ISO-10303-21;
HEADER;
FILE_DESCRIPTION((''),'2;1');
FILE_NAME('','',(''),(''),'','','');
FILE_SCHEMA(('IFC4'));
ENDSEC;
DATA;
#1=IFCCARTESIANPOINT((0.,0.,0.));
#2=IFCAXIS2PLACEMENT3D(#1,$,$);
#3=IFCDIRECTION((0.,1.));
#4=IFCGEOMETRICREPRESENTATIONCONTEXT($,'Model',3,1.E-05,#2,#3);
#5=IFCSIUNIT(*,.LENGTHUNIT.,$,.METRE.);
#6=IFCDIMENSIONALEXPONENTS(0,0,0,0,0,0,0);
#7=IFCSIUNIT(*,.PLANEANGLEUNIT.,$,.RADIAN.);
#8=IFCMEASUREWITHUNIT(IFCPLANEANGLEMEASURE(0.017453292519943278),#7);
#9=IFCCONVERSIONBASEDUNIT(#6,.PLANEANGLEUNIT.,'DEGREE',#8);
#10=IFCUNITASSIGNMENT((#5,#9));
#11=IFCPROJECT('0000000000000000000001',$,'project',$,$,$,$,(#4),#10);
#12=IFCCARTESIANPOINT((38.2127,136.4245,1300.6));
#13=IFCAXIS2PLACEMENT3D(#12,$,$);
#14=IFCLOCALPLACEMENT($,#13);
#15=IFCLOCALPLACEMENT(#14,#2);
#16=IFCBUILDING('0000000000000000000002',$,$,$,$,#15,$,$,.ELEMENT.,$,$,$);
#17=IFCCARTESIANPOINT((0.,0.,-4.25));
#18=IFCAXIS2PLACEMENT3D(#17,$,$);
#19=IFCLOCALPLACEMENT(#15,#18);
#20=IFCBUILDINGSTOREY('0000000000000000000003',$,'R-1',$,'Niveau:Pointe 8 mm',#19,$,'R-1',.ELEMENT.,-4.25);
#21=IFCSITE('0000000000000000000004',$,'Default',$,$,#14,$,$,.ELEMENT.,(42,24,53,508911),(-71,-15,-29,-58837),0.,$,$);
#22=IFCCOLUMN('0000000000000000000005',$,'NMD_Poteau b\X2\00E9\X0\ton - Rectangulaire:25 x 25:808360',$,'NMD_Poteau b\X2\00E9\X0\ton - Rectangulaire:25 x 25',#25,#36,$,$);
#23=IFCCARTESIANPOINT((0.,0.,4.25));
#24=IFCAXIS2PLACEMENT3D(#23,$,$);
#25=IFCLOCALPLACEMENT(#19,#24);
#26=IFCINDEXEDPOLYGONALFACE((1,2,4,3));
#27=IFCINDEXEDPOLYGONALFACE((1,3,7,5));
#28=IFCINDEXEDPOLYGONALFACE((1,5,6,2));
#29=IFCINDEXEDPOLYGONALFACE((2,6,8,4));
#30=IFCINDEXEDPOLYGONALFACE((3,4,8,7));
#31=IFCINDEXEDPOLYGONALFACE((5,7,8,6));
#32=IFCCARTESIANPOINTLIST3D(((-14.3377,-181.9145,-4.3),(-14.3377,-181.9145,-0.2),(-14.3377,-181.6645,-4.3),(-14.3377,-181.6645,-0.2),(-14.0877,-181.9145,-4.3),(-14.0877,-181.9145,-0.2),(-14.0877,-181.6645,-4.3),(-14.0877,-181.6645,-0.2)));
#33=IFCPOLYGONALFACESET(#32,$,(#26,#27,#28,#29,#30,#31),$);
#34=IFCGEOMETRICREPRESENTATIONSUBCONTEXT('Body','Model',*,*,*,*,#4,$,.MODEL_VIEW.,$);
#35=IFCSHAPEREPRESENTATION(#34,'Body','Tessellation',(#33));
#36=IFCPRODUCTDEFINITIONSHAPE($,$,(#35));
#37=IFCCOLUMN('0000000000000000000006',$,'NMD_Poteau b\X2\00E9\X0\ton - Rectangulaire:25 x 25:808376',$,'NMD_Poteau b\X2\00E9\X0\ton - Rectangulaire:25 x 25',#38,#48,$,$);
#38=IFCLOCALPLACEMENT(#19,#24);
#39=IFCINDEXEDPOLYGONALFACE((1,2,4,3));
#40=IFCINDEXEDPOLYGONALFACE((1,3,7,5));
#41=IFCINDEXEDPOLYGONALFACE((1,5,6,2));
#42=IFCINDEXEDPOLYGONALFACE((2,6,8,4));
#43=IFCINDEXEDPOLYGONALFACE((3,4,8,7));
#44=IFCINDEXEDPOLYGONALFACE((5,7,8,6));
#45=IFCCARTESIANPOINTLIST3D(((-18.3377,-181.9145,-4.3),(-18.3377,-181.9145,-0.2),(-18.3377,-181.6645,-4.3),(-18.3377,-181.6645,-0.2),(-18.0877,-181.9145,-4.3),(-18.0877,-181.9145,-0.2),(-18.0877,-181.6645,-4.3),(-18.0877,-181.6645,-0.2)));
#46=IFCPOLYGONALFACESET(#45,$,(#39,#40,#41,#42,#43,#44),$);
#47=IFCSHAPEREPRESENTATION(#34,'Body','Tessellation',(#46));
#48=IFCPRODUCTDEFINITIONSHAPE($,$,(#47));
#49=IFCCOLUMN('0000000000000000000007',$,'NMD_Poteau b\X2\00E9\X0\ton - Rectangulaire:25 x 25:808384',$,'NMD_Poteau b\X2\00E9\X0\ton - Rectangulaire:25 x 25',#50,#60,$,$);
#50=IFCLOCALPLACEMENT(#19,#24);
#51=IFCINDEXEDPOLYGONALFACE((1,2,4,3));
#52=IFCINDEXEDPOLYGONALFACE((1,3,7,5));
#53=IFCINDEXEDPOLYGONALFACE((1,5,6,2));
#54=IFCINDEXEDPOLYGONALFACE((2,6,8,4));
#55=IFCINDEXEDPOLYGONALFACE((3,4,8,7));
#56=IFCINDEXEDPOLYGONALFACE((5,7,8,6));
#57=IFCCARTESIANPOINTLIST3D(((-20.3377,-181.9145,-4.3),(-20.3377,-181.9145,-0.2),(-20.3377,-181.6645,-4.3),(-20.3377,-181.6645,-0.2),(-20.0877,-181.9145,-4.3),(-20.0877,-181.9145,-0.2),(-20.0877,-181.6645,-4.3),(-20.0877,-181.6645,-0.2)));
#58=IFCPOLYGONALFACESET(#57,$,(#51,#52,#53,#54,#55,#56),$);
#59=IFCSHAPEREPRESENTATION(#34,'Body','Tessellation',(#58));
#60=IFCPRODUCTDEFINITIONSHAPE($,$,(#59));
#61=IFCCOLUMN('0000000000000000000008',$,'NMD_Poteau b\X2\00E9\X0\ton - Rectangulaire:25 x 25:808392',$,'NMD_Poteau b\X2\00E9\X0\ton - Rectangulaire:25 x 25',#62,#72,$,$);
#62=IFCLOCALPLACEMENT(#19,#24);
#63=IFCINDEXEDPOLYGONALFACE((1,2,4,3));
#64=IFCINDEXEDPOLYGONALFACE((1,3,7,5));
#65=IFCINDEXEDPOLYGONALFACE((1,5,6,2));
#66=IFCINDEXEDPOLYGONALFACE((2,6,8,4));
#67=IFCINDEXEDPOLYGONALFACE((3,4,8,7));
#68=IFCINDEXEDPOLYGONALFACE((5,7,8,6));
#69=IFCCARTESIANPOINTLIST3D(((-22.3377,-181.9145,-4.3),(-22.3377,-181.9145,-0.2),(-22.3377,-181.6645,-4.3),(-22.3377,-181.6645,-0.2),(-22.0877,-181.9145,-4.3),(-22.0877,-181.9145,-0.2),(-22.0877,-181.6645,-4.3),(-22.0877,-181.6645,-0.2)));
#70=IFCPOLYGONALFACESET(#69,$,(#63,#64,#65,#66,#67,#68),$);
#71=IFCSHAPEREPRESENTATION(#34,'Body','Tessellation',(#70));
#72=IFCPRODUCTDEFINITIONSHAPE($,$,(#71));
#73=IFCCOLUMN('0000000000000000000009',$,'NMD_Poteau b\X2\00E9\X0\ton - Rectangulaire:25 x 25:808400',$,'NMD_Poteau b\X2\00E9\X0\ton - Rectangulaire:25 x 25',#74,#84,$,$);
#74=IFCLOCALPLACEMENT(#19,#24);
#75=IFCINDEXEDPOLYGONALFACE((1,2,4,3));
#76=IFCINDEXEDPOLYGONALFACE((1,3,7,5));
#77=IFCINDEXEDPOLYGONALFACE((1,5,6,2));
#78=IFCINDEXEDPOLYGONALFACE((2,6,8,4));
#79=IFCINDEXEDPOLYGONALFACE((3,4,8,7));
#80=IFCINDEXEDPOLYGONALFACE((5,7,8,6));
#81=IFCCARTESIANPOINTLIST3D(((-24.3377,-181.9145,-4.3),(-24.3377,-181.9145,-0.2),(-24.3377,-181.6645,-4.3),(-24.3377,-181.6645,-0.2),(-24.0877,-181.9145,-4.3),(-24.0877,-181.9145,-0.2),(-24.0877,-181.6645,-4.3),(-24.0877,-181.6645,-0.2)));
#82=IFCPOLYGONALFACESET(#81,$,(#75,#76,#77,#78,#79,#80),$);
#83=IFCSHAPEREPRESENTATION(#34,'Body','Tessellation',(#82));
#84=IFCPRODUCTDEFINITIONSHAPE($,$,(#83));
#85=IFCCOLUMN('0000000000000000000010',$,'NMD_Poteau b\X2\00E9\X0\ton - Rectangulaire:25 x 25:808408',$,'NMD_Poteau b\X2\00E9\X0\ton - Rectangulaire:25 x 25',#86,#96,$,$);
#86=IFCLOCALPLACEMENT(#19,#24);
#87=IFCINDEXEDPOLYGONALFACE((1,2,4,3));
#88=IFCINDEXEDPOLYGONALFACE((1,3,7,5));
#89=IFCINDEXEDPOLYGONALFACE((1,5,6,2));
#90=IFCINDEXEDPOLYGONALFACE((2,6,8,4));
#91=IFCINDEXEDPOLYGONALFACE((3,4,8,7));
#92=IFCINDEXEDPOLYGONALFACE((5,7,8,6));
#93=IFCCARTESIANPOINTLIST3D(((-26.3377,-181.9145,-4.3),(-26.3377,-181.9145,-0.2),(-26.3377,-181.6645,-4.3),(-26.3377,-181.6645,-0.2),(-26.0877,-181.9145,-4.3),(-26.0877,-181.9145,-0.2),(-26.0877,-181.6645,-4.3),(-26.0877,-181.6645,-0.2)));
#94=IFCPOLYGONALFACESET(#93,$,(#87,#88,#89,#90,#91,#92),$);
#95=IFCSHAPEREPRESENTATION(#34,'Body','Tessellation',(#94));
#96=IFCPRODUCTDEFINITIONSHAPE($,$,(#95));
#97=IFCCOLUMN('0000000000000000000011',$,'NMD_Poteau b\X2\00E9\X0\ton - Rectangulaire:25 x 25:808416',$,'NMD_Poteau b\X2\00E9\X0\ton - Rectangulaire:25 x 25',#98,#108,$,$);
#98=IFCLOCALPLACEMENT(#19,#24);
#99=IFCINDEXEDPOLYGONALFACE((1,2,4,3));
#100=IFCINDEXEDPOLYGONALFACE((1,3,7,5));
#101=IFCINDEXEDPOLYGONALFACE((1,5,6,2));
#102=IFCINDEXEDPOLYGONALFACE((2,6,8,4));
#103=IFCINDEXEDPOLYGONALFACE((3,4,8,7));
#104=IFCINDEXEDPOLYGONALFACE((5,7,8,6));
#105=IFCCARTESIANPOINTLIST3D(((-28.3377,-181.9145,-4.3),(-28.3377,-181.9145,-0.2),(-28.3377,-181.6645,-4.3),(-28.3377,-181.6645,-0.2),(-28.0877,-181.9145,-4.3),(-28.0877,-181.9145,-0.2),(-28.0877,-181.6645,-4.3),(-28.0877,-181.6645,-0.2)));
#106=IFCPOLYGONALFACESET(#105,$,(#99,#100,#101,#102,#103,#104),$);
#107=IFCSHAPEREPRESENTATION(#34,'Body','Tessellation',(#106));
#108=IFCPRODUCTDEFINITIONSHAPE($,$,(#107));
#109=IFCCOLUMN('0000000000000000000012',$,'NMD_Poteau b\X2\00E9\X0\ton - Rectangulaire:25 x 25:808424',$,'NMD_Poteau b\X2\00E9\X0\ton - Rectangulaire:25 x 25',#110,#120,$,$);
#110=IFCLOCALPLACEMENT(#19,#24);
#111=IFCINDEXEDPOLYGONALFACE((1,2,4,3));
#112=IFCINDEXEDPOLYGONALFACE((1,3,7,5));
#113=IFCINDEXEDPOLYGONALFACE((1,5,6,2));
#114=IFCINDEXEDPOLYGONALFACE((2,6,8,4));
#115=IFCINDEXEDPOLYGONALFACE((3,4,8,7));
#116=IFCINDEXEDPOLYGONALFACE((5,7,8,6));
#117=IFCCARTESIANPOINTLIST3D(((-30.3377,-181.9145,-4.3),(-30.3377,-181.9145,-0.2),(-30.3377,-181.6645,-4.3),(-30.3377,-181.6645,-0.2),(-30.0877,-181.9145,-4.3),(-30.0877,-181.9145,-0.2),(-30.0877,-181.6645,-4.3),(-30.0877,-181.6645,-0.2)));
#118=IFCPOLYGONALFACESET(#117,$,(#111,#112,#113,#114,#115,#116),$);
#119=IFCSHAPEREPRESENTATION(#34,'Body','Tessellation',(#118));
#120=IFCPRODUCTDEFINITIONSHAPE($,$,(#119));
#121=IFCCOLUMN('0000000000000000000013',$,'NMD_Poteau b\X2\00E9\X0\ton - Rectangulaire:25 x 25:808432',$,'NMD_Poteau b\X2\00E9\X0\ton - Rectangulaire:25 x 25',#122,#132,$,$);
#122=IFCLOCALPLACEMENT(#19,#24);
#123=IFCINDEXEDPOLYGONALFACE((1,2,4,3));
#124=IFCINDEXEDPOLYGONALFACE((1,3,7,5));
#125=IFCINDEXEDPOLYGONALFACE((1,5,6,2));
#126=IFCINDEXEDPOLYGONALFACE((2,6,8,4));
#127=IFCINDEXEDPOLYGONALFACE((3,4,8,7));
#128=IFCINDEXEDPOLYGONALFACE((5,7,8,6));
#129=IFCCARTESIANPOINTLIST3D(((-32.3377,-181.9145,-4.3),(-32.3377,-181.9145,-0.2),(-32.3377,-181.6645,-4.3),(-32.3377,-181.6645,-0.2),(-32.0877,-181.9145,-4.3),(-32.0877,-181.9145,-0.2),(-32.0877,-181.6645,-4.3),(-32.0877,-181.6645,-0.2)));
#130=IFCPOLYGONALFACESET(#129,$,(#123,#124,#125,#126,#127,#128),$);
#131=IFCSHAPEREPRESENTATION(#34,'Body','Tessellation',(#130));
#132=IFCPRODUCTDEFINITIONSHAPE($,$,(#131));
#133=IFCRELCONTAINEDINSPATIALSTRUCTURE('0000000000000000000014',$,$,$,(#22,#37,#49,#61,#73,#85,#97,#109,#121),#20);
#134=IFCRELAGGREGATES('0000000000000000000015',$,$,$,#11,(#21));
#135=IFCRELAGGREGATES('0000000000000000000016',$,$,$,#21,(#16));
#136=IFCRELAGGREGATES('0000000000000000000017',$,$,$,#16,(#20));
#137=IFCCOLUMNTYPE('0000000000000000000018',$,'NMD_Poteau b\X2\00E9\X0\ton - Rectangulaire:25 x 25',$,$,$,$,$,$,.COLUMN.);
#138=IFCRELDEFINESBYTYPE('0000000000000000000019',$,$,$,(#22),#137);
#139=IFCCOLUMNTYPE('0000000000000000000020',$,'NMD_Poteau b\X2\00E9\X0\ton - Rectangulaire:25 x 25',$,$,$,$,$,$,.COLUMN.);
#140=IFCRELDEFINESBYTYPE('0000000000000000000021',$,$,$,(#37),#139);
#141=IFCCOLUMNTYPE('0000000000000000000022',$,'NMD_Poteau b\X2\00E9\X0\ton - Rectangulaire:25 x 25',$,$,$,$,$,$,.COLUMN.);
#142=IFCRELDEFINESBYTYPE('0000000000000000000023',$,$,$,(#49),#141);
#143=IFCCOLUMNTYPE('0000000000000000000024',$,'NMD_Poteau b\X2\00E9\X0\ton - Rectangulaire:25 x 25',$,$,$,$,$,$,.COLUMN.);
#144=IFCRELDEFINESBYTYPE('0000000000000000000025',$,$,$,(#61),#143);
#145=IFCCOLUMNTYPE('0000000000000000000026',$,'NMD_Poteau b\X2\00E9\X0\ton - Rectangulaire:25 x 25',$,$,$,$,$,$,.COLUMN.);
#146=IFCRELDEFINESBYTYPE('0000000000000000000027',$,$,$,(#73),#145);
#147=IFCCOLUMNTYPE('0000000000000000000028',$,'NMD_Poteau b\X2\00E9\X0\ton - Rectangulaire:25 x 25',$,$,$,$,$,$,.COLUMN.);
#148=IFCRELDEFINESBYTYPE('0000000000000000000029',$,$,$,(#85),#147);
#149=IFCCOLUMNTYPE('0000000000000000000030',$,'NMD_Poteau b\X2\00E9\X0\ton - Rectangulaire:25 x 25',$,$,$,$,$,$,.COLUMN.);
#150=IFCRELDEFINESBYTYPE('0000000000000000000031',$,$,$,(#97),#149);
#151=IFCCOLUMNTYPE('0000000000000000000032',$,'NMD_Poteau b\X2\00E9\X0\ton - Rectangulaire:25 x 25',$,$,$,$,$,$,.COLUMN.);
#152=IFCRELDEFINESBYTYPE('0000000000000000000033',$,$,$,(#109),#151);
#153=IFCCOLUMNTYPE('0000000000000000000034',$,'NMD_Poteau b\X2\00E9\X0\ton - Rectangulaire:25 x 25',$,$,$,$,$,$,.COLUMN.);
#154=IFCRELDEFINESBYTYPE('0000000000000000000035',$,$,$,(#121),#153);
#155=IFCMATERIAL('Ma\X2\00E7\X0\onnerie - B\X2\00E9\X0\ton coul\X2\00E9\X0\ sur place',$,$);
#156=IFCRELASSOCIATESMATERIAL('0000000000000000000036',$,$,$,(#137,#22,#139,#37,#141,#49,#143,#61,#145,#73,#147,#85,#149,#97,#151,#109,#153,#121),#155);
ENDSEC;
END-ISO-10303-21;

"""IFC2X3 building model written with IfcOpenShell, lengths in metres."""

from ifc_helpers import new_model, entity, si_unit, converted_unit, direction, frame, frame_2d, origin, place, context, subcontext, project, spatial, rectangle, extrude, source, transform, mapped, material, type_object, type_shapes, element, save


model = new_model("IFC2X3")

# Units and contexts
model_context = context("Model", 3, precision=1e-05, world=origin(), true_north=direction((0.0, 1.0)))
body_context = subcontext(model_context, "Body", "Model", "MODEL_VIEW")
ifc_project = project(units=[si_unit("LENGTHUNIT", "METRE"), converted_unit("PLANEANGLEUNIT", "DEGREE", entity("IfcPlaneAngleMeasure", 0.017453292519943278), si_unit("PLANEANGLEUNIT", "RADIAN"), dimensions=[0, 0, 0, 0, 0, 0, 0])], contexts=[model_context])

# Site, building, storey
site_placement = place(None, frame((38.2127, 136.4245, 1300.6)))
site = spatial("IfcSite", under=ifc_project, at=site_placement, Name="Default", CompositionType="ELEMENT", RefLatitude=(42, 24, 53, 508911), RefLongitude=(-71, -15, -29, -58837), RefElevation=0.0)
building_placement = place(site_placement, origin())
building = spatial("IfcBuilding", under=site, at=building_placement, CompositionType="ELEMENT")
storey_placement = place(building_placement, frame((0.0, 0.0, -4.25)))
storey = spatial("IfcBuildingStorey", under=building, at=storey_placement, Name="R-1", ObjectType="Niveau:Pointe 8 mm", LongName="R-1", CompositionType="ELEMENT", Elevation=-4.25)

# Columns
ifc_material = material(Name="Maçonnerie - Béton coulé sur place")
column_type_1 = type_object("IfcColumnType", Name="NMD_Poteau béton - Rectangulaire:25 x 25", PredefinedType="COLUMN", material=ifc_material)
shared_shape_1 = source(origin(), body_context, "Body", "SweptSolid", [
    extrude(rectangle(XDim=0.25, YDim=0.25, at=frame_2d((0.0, 0.0), x_axis=(1.0, 0.0))), frame((-14.2127, -181.7895, -4.3), z_axis=(0.0, 0.0, 1.0), x_axis=(-1.0, 0.0, 0.0)), (0.0, 0.0, 1.0), 4.1),
])
type_shapes(column_type_1, [shared_shape_1])
column_1_placement = place(storey_placement, frame((0.0, 0.0, 4.25)))
element("IfcColumn", 1, at=column_1_placement, inside=storey, type_object=column_type_1, material=ifc_material, Name="NMD_Poteau béton - Rectangulaire:25 x 25:808360", ObjectType="NMD_Poteau béton - Rectangulaire:25 x 25", context=body_context, shape_type="MappedRepresentation", body=[
    mapped(shared_shape_1, transform((0.0, 0.0, 0.0), scale=1.0)),
])
column_type_2 = type_object("IfcColumnType", Name="NMD_Poteau béton - Rectangulaire:25 x 25", PredefinedType="COLUMN", material=ifc_material)
shared_shape_2 = source(origin(), body_context, "Body", "SweptSolid", [
    extrude(rectangle(XDim=0.25, YDim=0.25, at=frame_2d((0.0, 0.0), x_axis=(1.0, 0.0))), frame((-18.2127, -181.7895, -4.3), z_axis=(0.0, 0.0, 1.0), x_axis=(-1.0, 0.0, 0.0)), (0.0, 0.0, 1.0), 4.1),
])
type_shapes(column_type_2, [shared_shape_2])
column_2_placement = place(storey_placement, frame((0.0, 0.0, 4.25)))
element("IfcColumn", 2, at=column_2_placement, inside=storey, type_object=column_type_2, material=ifc_material, Name="NMD_Poteau béton - Rectangulaire:25 x 25:808376", ObjectType="NMD_Poteau béton - Rectangulaire:25 x 25", context=body_context, shape_type="MappedRepresentation", body=[
    mapped(shared_shape_2, transform((0.0, 0.0, 0.0), scale=1.0)),
])
column_type_3 = type_object("IfcColumnType", Name="NMD_Poteau béton - Rectangulaire:25 x 25", PredefinedType="COLUMN", material=ifc_material)
shared_shape_3 = source(origin(), body_context, "Body", "SweptSolid", [
    extrude(rectangle(XDim=0.25, YDim=0.25, at=frame_2d((0.0, 0.0), x_axis=(1.0, 0.0))), frame((-20.2127, -181.7895, -4.3), z_axis=(0.0, 0.0, 1.0), x_axis=(-1.0, 0.0, 0.0)), (0.0, 0.0, 1.0), 4.1),
])
type_shapes(column_type_3, [shared_shape_3])
column_3_placement = place(storey_placement, frame((0.0, 0.0, 4.25)))
element("IfcColumn", 3, at=column_3_placement, inside=storey, type_object=column_type_3, material=ifc_material, Name="NMD_Poteau béton - Rectangulaire:25 x 25:808384", ObjectType="NMD_Poteau béton - Rectangulaire:25 x 25", context=body_context, shape_type="MappedRepresentation", body=[
    mapped(shared_shape_3, transform((0.0, 0.0, 0.0), scale=1.0)),
])
column_type_4 = type_object("IfcColumnType", Name="NMD_Poteau béton - Rectangulaire:25 x 25", PredefinedType="COLUMN", material=ifc_material)
shared_shape_4 = source(origin(), body_context, "Body", "SweptSolid", [
    extrude(rectangle(XDim=0.25, YDim=0.25, at=frame_2d((0.0, 0.0), x_axis=(1.0, 0.0))), frame((-22.2127, -181.7895, -4.3), z_axis=(0.0, 0.0, 1.0), x_axis=(-1.0, 0.0, 0.0)), (0.0, 0.0, 1.0), 4.1),
])
type_shapes(column_type_4, [shared_shape_4])
column_4_placement = place(storey_placement, frame((0.0, 0.0, 4.25)))
element("IfcColumn", 4, at=column_4_placement, inside=storey, type_object=column_type_4, material=ifc_material, Name="NMD_Poteau béton - Rectangulaire:25 x 25:808392", ObjectType="NMD_Poteau béton - Rectangulaire:25 x 25", context=body_context, shape_type="MappedRepresentation", body=[
    mapped(shared_shape_4, transform((0.0, 0.0, 0.0), scale=1.0)),
])
column_type_5 = type_object("IfcColumnType", Name="NMD_Poteau béton - Rectangulaire:25 x 25", PredefinedType="COLUMN", material=ifc_material)
shared_shape_5 = source(origin(), body_context, "Body", "SweptSolid", [
    extrude(rectangle(XDim=0.25, YDim=0.25, at=frame_2d((0.0, 0.0), x_axis=(1.0, 0.0))), frame((-24.2127, -181.7895, -4.3), z_axis=(0.0, 0.0, 1.0), x_axis=(-1.0, 0.0, 0.0)), (0.0, 0.0, 1.0), 4.1),
])
type_shapes(column_type_5, [shared_shape_5])
column_5_placement = place(storey_placement, frame((0.0, 0.0, 4.25)))
element("IfcColumn", 5, at=column_5_placement, inside=storey, type_object=column_type_5, material=ifc_material, Name="NMD_Poteau béton - Rectangulaire:25 x 25:808400", ObjectType="NMD_Poteau béton - Rectangulaire:25 x 25", context=body_context, shape_type="MappedRepresentation", body=[
    mapped(shared_shape_5, transform((0.0, 0.0, 0.0), scale=1.0)),
])
column_type_6 = type_object("IfcColumnType", Name="NMD_Poteau béton - Rectangulaire:25 x 25", PredefinedType="COLUMN", material=ifc_material)
shared_shape_6 = source(origin(), body_context, "Body", "SweptSolid", [
    extrude(rectangle(XDim=0.25, YDim=0.25, at=frame_2d((0.0, 0.0), x_axis=(1.0, 0.0))), frame((-26.2127, -181.7895, -4.3), z_axis=(0.0, 0.0, 1.0), x_axis=(-1.0, 0.0, 0.0)), (0.0, 0.0, 1.0), 4.1),
])
type_shapes(column_type_6, [shared_shape_6])
column_6_placement = place(storey_placement, frame((0.0, 0.0, 4.25)))
element("IfcColumn", 6, at=column_6_placement, inside=storey, type_object=column_type_6, material=ifc_material, Name="NMD_Poteau béton - Rectangulaire:25 x 25:808408", ObjectType="NMD_Poteau béton - Rectangulaire:25 x 25", context=body_context, shape_type="MappedRepresentation", body=[
    mapped(shared_shape_6, transform((0.0, 0.0, 0.0), scale=1.0)),
])
column_type_7 = type_object("IfcColumnType", Name="NMD_Poteau béton - Rectangulaire:25 x 25", PredefinedType="COLUMN", material=ifc_material)
shared_shape_7 = source(origin(), body_context, "Body", "SweptSolid", [
    extrude(rectangle(XDim=0.25, YDim=0.25, at=frame_2d((0.0, 0.0), x_axis=(1.0, 0.0))), frame((-28.2127, -181.7895, -4.3), z_axis=(0.0, 0.0, 1.0), x_axis=(-1.0, 0.0, 0.0)), (0.0, 0.0, 1.0), 4.1),
])
type_shapes(column_type_7, [shared_shape_7])
column_7_placement = place(storey_placement, frame((0.0, 0.0, 4.25)))
element("IfcColumn", 7, at=column_7_placement, inside=storey, type_object=column_type_7, material=ifc_material, Name="NMD_Poteau béton - Rectangulaire:25 x 25:808416", ObjectType="NMD_Poteau béton - Rectangulaire:25 x 25", context=body_context, shape_type="MappedRepresentation", body=[
    mapped(shared_shape_7, transform((0.0, 0.0, 0.0), scale=1.0)),
])
column_type_8 = type_object("IfcColumnType", Name="NMD_Poteau béton - Rectangulaire:25 x 25", PredefinedType="COLUMN", material=ifc_material)
shared_shape_8 = source(origin(), body_context, "Body", "SweptSolid", [
    extrude(rectangle(XDim=0.25, YDim=0.25, at=frame_2d((0.0, 0.0), x_axis=(1.0, 0.0))), frame((-30.2127, -181.7895, -4.3), z_axis=(0.0, 0.0, 1.0), x_axis=(-1.0, 0.0, 0.0)), (0.0, 0.0, 1.0), 4.1),
])
type_shapes(column_type_8, [shared_shape_8])
column_8_placement = place(storey_placement, frame((0.0, 0.0, 4.25)))
element("IfcColumn", 8, at=column_8_placement, inside=storey, type_object=column_type_8, material=ifc_material, Name="NMD_Poteau béton - Rectangulaire:25 x 25:808424", ObjectType="NMD_Poteau béton - Rectangulaire:25 x 25", context=body_context, shape_type="MappedRepresentation", body=[
    mapped(shared_shape_8, transform((0.0, 0.0, 0.0), scale=1.0)),
])
column_type_9 = type_object("IfcColumnType", Name="NMD_Poteau béton - Rectangulaire:25 x 25", PredefinedType="COLUMN", material=ifc_material)
shared_shape_9 = source(origin(), body_context, "Body", "SweptSolid", [
    extrude(rectangle(XDim=0.25, YDim=0.25, at=frame_2d((0.0, 0.0), x_axis=(1.0, 0.0))), frame((-32.2127, -181.7895, -4.3), z_axis=(0.0, 0.0, 1.0), x_axis=(-1.0, 0.0, 0.0)), (0.0, 0.0, 1.0), 4.1),
])
type_shapes(column_type_9, [shared_shape_9])
column_9_placement = place(storey_placement, frame((0.0, 0.0, 4.25)))
element("IfcColumn", 9, at=column_9_placement, inside=storey, type_object=column_type_9, material=ifc_material, Name="NMD_Poteau béton - Rectangulaire:25 x 25:808432", ObjectType="NMD_Poteau béton - Rectangulaire:25 x 25", context=body_context, shape_type="MappedRepresentation", body=[
    mapped(shared_shape_9, transform((0.0, 0.0, 0.0), scale=1.0)),
])

save(model, "model.ifc")
